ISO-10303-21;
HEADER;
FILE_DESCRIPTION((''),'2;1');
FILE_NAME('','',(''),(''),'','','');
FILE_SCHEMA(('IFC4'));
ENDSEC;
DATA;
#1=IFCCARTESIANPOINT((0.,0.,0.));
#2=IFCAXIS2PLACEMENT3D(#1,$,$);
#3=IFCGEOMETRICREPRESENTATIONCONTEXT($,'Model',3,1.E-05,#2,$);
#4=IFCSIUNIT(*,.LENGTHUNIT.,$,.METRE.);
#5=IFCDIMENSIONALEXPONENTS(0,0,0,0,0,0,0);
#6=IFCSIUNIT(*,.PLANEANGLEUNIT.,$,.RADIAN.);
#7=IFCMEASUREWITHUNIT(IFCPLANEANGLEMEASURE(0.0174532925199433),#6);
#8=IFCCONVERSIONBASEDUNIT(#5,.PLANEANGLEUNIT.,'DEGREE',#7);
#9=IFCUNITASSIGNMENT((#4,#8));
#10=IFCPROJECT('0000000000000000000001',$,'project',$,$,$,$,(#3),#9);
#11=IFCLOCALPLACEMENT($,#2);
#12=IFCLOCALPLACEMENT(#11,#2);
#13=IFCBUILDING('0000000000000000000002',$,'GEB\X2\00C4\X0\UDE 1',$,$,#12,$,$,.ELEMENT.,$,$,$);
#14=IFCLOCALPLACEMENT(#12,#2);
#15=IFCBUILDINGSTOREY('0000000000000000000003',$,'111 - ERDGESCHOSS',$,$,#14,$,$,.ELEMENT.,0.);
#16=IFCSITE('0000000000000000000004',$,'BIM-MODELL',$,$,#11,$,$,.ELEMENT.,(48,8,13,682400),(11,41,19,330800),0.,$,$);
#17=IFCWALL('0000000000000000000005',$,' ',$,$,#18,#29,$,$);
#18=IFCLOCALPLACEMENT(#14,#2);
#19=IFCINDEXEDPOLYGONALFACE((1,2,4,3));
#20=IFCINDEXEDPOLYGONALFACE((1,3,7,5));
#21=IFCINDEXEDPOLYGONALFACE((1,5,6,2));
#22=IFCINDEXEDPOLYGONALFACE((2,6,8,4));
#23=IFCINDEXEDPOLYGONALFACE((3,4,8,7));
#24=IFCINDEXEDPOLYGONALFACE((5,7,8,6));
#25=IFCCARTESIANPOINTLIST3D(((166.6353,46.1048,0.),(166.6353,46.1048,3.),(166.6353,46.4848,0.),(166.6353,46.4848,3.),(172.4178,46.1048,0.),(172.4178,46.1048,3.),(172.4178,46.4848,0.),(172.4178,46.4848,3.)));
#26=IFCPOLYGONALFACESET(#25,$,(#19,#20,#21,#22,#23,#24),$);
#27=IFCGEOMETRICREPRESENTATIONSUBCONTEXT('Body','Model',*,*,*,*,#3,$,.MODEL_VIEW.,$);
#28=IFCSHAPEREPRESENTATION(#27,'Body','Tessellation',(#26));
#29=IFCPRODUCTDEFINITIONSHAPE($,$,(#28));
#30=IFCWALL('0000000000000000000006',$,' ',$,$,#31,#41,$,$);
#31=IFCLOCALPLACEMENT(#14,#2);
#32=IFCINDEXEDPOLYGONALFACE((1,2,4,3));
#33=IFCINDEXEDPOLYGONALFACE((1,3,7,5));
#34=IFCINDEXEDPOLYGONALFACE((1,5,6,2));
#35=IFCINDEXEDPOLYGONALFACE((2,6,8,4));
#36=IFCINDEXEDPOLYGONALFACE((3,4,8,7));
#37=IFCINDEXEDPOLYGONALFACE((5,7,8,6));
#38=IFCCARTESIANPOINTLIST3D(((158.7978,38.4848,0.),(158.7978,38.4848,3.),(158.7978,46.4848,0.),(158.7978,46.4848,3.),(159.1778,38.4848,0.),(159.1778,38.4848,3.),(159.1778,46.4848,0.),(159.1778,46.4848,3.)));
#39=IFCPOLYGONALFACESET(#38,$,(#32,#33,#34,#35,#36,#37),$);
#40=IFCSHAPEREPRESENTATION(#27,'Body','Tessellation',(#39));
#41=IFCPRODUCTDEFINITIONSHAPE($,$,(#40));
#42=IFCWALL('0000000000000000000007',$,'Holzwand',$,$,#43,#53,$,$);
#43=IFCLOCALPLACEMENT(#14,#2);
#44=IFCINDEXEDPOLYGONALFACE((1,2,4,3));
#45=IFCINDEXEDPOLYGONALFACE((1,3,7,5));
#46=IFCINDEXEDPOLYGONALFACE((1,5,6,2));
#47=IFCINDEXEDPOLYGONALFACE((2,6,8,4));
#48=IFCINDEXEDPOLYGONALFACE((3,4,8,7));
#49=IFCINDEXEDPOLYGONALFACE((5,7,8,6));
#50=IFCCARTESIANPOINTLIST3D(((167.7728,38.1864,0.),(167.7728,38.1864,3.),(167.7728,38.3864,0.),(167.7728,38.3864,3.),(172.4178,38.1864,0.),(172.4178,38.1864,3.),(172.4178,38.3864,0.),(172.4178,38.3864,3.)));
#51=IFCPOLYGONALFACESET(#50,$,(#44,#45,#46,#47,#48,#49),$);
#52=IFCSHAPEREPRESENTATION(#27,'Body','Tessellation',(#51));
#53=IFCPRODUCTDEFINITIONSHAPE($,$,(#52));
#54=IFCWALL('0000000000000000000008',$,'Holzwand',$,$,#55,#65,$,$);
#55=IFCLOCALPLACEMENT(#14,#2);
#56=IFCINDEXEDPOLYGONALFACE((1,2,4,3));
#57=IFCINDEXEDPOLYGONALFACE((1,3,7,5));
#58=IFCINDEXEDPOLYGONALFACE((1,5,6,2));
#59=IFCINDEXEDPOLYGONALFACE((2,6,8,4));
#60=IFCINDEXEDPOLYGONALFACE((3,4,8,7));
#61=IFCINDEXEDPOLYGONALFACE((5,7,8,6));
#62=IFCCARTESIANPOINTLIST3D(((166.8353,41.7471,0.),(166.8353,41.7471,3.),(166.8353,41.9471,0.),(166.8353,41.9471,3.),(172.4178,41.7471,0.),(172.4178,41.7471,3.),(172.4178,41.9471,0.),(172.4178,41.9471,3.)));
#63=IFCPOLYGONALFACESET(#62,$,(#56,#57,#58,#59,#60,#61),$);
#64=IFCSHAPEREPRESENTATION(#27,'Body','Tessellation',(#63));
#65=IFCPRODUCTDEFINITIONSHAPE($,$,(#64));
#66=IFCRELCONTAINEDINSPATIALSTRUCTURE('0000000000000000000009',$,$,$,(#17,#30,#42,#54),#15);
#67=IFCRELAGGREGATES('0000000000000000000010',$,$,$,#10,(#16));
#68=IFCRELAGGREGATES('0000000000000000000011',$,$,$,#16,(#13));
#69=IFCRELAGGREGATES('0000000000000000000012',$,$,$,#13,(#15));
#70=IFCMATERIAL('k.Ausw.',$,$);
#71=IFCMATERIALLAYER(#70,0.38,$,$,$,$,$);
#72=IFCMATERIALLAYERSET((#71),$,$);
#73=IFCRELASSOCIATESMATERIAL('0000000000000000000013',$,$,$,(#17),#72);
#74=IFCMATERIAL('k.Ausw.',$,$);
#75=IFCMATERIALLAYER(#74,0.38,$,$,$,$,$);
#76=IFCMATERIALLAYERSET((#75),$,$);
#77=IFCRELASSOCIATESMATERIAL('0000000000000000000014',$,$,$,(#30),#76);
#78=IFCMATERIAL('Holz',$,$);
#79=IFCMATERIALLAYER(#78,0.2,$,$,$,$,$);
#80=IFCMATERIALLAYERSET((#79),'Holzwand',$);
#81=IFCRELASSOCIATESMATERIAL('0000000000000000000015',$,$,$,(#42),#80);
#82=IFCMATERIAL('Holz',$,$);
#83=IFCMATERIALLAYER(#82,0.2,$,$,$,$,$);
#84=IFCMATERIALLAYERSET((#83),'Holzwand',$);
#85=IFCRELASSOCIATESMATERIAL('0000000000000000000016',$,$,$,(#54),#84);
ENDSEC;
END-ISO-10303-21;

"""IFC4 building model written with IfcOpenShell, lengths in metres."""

from ifc_helpers import new_model, entity, si_unit, converted_unit, frame, frame_2d, origin, origin_with_axes, place, context, subcontext, project, spatial, rectangle, extrude, material, layer, layer_set, layer_usage, element, save


model = new_model("IFC4")

# Units and contexts
model_context = context("Model", 3, precision=1e-05, world=origin())
body_context = subcontext(model_context, "Body", "Model", "MODEL_VIEW")
ifc_project = project(units=[si_unit("LENGTHUNIT", "METRE"), converted_unit("PLANEANGLEUNIT", "DEGREE", entity("IfcPlaneAngleMeasure", 0.0174532925199433), si_unit("PLANEANGLEUNIT", "RADIAN"), dimensions=[0, 0, 0, 0, 0, 0, 0])], contexts=[model_context])

# Site, building, storey
site_placement = place(None, origin())
site = spatial("IfcSite", under=ifc_project, at=site_placement, Name="BIM-MODELL", CompositionType="ELEMENT", RefLatitude=(48, 8, 13, 682400), RefLongitude=(11, 41, 19, 330800), RefElevation=0.0)
building_placement = place(site_placement, origin())
building = spatial("IfcBuilding", under=site, at=building_placement, Name="GEBÄUDE 1", CompositionType="ELEMENT")
storey_placement = place(building_placement, origin())
storey = spatial("IfcBuildingStorey", under=building, at=storey_placement, Name="111 - ERDGESCHOSS", CompositionType="ELEMENT", Elevation=0.0)

# Walls
ifc_material_1 = material(Name="k.Ausw.")
ifc_layer_1 = layer(ifc_material_1, 0.38)
ifc_layer_set_1 = layer_set([ifc_layer_1])
ifc_layer_usage_1 = layer_usage(ifc_layer_set_1, "AXIS2", "POSITIVE", 0.0)
wall_1_placement = place(storey_placement, frame((172.4178, 46.4848, 0.0), z_axis=(0.0, 0.0, 1.0), x_axis=(-1.0, 0.0, 0.0)))
element("IfcWall", 1, at=wall_1_placement, inside=storey, material=ifc_layer_usage_1, Name=" ", context=body_context, shape_type="SweptSolid", body=[
    extrude(rectangle(XDim=5.7825, YDim=0.38, at=frame_2d((2.8913, 0.19), x_axis=(1.0, 0.0))), origin_with_axes(), (0.0, 0.0, 1.0), 3.0),
])
ifc_material_2 = material(Name="k.Ausw.")
ifc_layer_2 = layer(ifc_material_2, 0.38)
ifc_layer_set_2 = layer_set([ifc_layer_2])
ifc_layer_usage_2 = layer_usage(ifc_layer_set_2, "AXIS2", "POSITIVE", 0.0)
wall_2_placement = place(storey_placement, frame((158.7978, 46.4848, 0.0), z_axis=(0.0, 0.0, 1.0), x_axis=(0.0, -1.0, 0.0)))
element("IfcWall", 2, at=wall_2_placement, inside=storey, material=ifc_layer_usage_2, Name=" ", context=body_context, shape_type="SweptSolid", body=[
    extrude(rectangle(XDim=8.0, YDim=0.38, at=frame_2d((4.0, 0.19), x_axis=(1.0, 0.0))), origin_with_axes(), (0.0, 0.0, 1.0), 3.0),
])
ifc_material_3 = material(Name="Holz")
ifc_layer_3 = layer(ifc_material_3, 0.2)
ifc_layer_set_3 = layer_set([ifc_layer_3], Name="Holzwand")
ifc_layer_usage_3 = layer_usage(ifc_layer_set_3, "AXIS2", "POSITIVE", 0.0)
wall_3_placement = place(storey_placement, frame((172.4178, 38.3864, 0.0), z_axis=(0.0, 0.0, 1.0), x_axis=(-1.0, 0.0, 0.0)))
element("IfcWall", 3, at=wall_3_placement, inside=storey, material=ifc_layer_usage_3, Name="Holzwand", context=body_context, shape_type="SweptSolid", body=[
    extrude(rectangle(XDim=4.645, YDim=0.2, at=frame_2d((2.3225, 0.1), x_axis=(1.0, 0.0))), origin_with_axes(), (0.0, 0.0, 1.0), 3.0),
])
ifc_material_4 = material(Name="Holz")
ifc_layer_4 = layer(ifc_material_4, 0.2)
ifc_layer_set_4 = layer_set([ifc_layer_4], Name="Holzwand")
ifc_layer_usage_4 = layer_usage(ifc_layer_set_4, "AXIS2", "POSITIVE", 0.0)
wall_4_placement = place(storey_placement, frame((172.4178, 41.9471, 0.0), z_axis=(0.0, 0.0, 1.0), x_axis=(-1.0, 0.0, 0.0)))
element("IfcWall", 4, at=wall_4_placement, inside=storey, material=ifc_layer_usage_4, Name="Holzwand", context=body_context, shape_type="SweptSolid", body=[
    extrude(rectangle(XDim=5.5825, YDim=0.2, at=frame_2d((2.7912, 0.1), x_axis=(1.0, 0.0))), origin_with_axes(), (0.0, 0.0, 1.0), 3.0),
])

save(model, "model.ifc")
